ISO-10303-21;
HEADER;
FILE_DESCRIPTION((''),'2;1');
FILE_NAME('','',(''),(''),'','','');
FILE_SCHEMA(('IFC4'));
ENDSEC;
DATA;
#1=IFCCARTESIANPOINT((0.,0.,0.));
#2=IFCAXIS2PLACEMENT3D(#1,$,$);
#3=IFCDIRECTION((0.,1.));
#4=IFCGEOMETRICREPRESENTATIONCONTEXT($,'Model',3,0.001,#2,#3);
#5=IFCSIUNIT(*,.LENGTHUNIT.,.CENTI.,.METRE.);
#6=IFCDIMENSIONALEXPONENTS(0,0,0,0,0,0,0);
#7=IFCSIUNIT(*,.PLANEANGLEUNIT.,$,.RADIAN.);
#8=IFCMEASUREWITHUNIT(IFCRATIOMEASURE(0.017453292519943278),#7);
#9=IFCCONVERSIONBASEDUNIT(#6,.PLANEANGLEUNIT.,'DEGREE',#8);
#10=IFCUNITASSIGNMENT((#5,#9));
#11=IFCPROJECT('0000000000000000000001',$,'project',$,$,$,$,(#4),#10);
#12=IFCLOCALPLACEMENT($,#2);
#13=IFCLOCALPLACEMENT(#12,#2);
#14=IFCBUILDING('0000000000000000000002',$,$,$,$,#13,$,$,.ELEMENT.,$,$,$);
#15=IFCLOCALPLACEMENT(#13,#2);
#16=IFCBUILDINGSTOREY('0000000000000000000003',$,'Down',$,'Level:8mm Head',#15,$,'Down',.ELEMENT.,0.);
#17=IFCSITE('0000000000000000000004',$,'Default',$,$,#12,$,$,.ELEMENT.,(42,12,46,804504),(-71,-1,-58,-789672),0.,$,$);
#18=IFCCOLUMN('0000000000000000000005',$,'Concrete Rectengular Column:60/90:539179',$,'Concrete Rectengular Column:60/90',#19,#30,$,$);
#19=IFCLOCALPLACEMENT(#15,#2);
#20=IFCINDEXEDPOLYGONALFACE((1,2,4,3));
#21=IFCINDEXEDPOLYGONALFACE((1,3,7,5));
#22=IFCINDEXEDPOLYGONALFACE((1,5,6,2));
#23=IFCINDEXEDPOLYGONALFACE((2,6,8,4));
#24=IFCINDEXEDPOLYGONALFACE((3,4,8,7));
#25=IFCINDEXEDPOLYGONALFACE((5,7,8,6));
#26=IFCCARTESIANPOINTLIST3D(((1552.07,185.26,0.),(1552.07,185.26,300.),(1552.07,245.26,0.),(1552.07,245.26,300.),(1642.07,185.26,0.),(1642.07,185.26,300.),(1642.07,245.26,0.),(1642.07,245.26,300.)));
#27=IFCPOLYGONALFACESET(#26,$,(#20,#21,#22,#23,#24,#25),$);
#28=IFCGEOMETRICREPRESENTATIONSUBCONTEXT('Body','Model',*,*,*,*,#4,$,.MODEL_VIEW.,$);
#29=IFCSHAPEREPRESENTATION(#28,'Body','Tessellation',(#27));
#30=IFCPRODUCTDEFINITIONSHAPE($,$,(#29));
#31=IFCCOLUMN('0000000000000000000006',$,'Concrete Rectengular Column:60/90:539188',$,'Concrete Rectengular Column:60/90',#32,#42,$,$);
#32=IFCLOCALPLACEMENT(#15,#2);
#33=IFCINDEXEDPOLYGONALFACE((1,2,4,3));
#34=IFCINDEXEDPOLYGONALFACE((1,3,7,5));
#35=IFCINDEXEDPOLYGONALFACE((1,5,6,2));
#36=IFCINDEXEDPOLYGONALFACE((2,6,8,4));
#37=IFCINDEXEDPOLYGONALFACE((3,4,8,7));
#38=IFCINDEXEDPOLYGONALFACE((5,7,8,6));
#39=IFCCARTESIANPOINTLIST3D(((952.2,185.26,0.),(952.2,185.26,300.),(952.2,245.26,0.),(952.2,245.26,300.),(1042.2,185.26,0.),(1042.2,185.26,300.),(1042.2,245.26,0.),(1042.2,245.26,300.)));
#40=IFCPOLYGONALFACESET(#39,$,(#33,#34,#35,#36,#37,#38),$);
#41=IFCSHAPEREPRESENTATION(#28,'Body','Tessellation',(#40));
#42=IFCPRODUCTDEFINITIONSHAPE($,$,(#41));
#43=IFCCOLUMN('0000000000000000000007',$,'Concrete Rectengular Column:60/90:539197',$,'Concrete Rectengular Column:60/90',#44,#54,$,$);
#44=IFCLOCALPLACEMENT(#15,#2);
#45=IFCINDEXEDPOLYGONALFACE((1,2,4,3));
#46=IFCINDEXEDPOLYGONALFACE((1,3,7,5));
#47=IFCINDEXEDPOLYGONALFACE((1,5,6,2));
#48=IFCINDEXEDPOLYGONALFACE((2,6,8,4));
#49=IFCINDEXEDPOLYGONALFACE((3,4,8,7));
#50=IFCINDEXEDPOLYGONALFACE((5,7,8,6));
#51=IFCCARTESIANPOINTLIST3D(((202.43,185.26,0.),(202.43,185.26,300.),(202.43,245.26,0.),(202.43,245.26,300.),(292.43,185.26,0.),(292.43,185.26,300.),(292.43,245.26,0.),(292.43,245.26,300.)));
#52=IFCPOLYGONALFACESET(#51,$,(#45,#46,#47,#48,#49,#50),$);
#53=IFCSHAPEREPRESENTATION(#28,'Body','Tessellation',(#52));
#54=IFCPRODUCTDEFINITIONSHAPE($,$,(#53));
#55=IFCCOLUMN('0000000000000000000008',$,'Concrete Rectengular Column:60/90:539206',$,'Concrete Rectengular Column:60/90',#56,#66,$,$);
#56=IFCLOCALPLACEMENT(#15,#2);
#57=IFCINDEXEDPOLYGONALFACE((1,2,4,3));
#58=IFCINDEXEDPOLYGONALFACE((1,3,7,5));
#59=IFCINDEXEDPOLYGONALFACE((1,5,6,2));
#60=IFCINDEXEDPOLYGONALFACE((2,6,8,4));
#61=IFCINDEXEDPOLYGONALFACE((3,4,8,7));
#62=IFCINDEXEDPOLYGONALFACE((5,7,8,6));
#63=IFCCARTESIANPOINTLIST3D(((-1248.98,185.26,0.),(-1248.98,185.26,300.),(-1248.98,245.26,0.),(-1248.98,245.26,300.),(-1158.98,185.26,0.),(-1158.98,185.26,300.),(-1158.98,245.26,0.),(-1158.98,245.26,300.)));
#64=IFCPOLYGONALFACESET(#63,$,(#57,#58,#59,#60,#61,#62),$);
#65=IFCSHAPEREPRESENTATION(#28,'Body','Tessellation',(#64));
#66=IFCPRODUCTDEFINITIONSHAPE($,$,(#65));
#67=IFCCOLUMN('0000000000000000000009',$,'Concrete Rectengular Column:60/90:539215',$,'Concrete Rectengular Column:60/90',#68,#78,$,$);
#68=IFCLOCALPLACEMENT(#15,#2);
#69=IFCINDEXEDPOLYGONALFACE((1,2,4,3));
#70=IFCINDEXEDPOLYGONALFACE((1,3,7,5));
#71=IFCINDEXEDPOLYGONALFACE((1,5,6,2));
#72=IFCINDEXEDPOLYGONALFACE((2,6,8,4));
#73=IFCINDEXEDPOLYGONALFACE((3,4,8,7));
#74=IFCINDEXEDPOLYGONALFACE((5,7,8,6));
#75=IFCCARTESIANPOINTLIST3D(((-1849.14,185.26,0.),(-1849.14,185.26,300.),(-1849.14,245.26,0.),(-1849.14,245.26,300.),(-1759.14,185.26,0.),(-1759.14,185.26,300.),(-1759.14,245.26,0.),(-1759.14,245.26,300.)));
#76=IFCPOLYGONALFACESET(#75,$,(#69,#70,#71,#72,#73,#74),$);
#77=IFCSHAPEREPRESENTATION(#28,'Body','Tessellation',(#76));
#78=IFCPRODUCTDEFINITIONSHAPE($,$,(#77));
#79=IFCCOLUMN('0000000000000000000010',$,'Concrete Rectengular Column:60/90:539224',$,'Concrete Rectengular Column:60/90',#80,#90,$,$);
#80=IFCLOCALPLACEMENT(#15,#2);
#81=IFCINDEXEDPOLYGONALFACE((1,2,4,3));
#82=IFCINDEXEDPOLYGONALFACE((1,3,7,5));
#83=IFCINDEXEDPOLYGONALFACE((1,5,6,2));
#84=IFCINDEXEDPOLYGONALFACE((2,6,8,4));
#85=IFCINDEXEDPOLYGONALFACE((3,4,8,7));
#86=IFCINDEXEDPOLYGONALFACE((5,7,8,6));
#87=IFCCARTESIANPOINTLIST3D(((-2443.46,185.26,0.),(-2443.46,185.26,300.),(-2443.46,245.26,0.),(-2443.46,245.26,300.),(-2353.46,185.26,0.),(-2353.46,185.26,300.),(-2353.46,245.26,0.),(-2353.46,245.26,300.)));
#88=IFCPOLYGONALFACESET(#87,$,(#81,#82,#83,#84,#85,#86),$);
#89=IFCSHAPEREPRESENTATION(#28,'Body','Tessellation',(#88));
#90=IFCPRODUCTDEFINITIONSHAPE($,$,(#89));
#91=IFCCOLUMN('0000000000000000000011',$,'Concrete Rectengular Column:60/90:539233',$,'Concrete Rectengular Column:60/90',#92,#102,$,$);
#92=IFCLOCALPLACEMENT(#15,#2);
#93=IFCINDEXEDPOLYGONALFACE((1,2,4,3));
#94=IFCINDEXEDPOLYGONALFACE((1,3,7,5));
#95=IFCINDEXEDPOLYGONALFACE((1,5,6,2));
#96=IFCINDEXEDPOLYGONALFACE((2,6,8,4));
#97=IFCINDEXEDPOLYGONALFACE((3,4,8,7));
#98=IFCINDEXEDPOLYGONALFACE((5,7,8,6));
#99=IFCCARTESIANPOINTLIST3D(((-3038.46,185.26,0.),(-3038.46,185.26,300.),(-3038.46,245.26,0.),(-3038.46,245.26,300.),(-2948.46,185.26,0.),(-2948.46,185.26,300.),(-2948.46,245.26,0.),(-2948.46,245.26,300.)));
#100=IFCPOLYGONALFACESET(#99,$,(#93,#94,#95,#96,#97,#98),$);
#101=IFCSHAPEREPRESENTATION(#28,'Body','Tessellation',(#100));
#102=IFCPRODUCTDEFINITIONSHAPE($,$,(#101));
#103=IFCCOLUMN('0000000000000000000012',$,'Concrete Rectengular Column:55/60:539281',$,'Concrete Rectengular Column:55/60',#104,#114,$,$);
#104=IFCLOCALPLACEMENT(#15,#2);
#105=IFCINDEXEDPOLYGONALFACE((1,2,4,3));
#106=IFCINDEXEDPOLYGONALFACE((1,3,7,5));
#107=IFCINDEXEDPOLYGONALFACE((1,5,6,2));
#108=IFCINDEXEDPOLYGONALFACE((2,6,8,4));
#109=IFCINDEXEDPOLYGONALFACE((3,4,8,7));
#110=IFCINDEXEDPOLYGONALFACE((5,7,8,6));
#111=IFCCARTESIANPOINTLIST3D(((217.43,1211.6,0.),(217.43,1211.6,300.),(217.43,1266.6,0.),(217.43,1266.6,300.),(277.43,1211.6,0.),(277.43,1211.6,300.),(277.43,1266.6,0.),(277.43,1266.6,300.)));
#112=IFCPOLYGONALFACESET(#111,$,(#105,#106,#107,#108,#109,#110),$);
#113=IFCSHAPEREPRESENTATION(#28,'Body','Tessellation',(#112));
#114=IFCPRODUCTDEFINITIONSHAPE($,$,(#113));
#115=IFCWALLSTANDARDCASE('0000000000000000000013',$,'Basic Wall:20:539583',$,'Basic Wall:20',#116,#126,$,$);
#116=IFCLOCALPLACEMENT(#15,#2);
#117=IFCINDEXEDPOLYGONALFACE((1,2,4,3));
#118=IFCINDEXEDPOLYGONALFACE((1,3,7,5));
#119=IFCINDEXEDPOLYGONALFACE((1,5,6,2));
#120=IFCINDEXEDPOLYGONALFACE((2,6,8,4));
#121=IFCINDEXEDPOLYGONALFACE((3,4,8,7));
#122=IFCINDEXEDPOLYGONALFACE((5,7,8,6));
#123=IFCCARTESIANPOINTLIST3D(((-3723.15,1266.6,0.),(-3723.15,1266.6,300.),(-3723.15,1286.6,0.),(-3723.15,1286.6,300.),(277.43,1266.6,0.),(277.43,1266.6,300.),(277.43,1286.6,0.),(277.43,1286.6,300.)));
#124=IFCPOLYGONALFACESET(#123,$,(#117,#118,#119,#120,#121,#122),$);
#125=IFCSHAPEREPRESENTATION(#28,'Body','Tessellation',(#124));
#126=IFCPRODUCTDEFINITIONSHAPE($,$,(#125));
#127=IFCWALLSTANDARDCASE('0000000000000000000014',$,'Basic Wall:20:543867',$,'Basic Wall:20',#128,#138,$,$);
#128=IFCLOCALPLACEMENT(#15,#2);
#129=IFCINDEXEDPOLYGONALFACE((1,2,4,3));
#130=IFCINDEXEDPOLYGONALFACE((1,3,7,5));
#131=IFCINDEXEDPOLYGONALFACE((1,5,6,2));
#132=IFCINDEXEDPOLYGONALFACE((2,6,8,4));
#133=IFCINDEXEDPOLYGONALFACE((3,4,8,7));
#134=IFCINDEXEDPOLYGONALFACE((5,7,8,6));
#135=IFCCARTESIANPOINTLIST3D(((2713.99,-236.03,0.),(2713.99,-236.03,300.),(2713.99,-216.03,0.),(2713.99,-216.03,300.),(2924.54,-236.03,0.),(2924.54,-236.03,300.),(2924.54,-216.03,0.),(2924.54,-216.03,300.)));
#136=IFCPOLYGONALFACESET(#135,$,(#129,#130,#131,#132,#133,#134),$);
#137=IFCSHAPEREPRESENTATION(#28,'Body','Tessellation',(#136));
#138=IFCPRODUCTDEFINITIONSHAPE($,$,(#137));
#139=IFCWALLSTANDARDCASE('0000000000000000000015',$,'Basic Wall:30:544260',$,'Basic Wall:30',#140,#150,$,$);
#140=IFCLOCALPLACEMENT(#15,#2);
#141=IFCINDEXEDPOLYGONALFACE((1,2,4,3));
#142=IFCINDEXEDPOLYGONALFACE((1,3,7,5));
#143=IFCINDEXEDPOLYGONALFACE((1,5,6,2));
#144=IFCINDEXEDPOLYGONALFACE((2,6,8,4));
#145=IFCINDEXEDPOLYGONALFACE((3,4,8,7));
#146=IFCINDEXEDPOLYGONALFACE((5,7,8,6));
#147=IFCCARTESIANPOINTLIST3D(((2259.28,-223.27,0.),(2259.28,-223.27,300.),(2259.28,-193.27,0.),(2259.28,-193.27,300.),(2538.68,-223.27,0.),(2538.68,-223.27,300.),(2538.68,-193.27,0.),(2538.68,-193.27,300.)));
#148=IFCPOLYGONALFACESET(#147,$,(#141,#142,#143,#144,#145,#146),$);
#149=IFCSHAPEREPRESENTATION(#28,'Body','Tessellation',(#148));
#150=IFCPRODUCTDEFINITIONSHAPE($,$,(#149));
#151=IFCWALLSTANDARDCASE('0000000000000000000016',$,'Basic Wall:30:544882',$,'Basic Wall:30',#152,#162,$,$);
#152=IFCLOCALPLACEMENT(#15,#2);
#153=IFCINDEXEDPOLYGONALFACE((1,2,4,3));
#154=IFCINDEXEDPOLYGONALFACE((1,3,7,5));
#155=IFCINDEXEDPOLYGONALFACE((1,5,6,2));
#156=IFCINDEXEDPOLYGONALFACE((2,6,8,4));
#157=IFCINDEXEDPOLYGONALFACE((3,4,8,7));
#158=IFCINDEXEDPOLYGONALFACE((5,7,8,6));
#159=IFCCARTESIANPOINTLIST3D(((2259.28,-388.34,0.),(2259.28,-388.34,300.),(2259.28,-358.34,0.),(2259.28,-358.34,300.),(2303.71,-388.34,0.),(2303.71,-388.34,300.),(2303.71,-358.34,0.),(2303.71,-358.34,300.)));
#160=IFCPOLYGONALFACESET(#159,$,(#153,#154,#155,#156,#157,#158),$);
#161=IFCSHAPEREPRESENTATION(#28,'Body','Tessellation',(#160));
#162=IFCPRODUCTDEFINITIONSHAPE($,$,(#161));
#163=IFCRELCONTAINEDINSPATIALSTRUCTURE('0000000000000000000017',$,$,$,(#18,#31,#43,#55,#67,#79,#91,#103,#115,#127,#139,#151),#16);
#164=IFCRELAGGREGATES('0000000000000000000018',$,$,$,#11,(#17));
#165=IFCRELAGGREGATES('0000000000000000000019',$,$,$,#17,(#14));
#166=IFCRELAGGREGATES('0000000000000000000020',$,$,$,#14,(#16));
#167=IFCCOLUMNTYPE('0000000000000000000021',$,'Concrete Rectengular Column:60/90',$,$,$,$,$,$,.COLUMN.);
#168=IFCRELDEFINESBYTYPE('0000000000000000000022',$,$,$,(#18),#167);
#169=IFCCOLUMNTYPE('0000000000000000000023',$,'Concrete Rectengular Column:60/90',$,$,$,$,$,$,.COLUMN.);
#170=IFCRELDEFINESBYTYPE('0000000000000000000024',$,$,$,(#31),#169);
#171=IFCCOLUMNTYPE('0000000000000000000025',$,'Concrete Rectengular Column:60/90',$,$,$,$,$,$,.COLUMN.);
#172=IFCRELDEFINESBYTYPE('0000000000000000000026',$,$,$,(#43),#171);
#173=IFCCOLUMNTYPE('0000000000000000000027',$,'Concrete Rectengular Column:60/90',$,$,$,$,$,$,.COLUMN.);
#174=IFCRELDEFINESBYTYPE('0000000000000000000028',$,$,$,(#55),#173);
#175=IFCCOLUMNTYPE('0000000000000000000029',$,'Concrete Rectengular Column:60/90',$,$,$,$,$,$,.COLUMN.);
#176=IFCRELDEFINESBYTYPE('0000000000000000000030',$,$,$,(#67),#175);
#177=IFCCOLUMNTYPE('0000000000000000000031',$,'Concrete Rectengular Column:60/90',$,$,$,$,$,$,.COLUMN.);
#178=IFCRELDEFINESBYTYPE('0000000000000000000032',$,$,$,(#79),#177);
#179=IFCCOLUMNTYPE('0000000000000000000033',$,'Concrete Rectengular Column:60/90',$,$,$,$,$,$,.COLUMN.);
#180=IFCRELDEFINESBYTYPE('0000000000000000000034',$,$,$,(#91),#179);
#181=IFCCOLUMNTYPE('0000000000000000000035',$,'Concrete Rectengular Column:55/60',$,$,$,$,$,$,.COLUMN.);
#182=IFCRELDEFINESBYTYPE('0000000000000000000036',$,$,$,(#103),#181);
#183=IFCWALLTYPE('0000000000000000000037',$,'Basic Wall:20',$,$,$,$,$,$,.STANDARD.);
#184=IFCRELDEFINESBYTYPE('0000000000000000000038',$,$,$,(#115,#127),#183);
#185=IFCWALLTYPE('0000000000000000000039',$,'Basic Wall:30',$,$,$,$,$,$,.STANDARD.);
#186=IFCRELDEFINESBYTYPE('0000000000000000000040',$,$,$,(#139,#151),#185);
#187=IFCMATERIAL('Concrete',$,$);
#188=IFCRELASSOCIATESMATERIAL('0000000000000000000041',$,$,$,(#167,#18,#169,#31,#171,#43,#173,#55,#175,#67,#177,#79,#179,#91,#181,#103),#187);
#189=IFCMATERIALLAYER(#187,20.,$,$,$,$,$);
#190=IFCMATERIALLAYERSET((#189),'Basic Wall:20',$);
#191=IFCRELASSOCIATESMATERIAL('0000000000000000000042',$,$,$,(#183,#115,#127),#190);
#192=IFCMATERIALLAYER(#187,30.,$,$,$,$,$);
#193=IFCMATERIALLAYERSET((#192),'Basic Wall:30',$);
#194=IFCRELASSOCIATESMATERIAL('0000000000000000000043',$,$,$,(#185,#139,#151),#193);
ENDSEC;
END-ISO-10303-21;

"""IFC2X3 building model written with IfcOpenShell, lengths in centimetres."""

from ifc_helpers import new_model, entity, si_unit, converted_unit, direction, frame, frame_2d, origin, origin_2d_with_axis, place, context, subcontext, project, spatial, rectangle, extrude, source, transform, mapped, material, layer, layer_set, layer_usage, type_object, type_shapes, element, save


model = new_model("IFC2X3")

# Units and contexts
model_context = context("Model", 3, precision=0.001, world=origin(), true_north=direction((0.0, 1.0)))
body_context = subcontext(model_context, "Body", "Model", "MODEL_VIEW")
ifc_project = project(units=[si_unit("LENGTHUNIT", "METRE", prefix="CENTI"), converted_unit("PLANEANGLEUNIT", "DEGREE", entity("IfcRatioMeasure", 0.017453292519943278), si_unit("PLANEANGLEUNIT", "RADIAN"), dimensions=[0, 0, 0, 0, 0, 0, 0])], contexts=[model_context])

# Site, building, storey
site_placement = place(None, origin())
site = spatial("IfcSite", under=ifc_project, at=site_placement, Name="Default", CompositionType="ELEMENT", RefLatitude=(42, 12, 46, 804504), RefLongitude=(-71, -1, -58, -789672), RefElevation=0.0)
building_placement = place(site_placement, origin())
building = spatial("IfcBuilding", under=site, at=building_placement, CompositionType="ELEMENT")
storey_placement = place(building_placement, origin())
storey = spatial("IfcBuildingStorey", under=building, at=storey_placement, Name="Down", ObjectType="Level:8mm Head", LongName="Down", CompositionType="ELEMENT", Elevation=0.0)

# Columns
ifc_material = material(Name="Concrete")
column_type_1 = type_object("IfcColumnType", Name="Concrete Rectengular Column:60/90", PredefinedType="COLUMN", material=ifc_material)
shared_shape_1 = source(origin(), body_context, "Body", "SweptSolid", [
    extrude(rectangle(XDim=60.0, YDim=90.0, at=frame_2d((0.0, 0.0), x_axis=(1.0, 0.0))), frame((1597.07, 215.26, 0.0), z_axis=(0.0, 0.0, 1.0), x_axis=(0.0, -1.0, 0.0)), (0.0, 0.0, 1.0), 300.0),
])
type_shapes(column_type_1, [shared_shape_1])
column_1_placement = place(storey_placement, origin())
element("IfcColumn", 1, at=column_1_placement, inside=storey, type_object=column_type_1, material=ifc_material, Name="Concrete Rectengular Column:60/90:539179", ObjectType="Concrete Rectengular Column:60/90", context=body_context, shape_type="MappedRepresentation", body=[
    mapped(shared_shape_1, transform((0.0, 0.0, 0.0), scale=1.0)),
])
column_type_2 = type_object("IfcColumnType", Name="Concrete Rectengular Column:60/90", PredefinedType="COLUMN", material=ifc_material)
shared_shape_2 = source(origin(), body_context, "Body", "SweptSolid", [
    extrude(rectangle(XDim=60.0, YDim=90.0, at=frame_2d((0.0, 0.0), x_axis=(1.0, 0.0))), frame((997.2, 215.26, 0.0), z_axis=(0.0, 0.0, 1.0), x_axis=(0.0, -1.0, 0.0)), (0.0, 0.0, 1.0), 300.0),
])
type_shapes(column_type_2, [shared_shape_2])
column_2_placement = place(storey_placement, origin())
element("IfcColumn", 2, at=column_2_placement, inside=storey, type_object=column_type_2, material=ifc_material, Name="Concrete Rectengular Column:60/90:539188", ObjectType="Concrete Rectengular Column:60/90", context=body_context, shape_type="MappedRepresentation", body=[
    mapped(shared_shape_2, transform((0.0, 0.0, 0.0), scale=1.0)),
])
column_type_3 = type_object("IfcColumnType", Name="Concrete Rectengular Column:60/90", PredefinedType="COLUMN", material=ifc_material)
shared_shape_3 = source(origin(), body_context, "Body", "SweptSolid", [
    extrude(rectangle(XDim=60.0, YDim=90.0, at=frame_2d((0.0, 0.0), x_axis=(1.0, 0.0))), frame((247.43, 215.26, 0.0), z_axis=(0.0, 0.0, 1.0), x_axis=(0.0, -1.0, 0.0)), (0.0, 0.0, 1.0), 300.0),
])
type_shapes(column_type_3, [shared_shape_3])
column_3_placement = place(storey_placement, origin())
element("IfcColumn", 3, at=column_3_placement, inside=storey, type_object=column_type_3, material=ifc_material, Name="Concrete Rectengular Column:60/90:539197", ObjectType="Concrete Rectengular Column:60/90", context=body_context, shape_type="MappedRepresentation", body=[
    mapped(shared_shape_3, transform((0.0, 0.0, 0.0), scale=1.0)),
])
column_type_4 = type_object("IfcColumnType", Name="Concrete Rectengular Column:60/90", PredefinedType="COLUMN", material=ifc_material)
shared_shape_4 = source(origin(), body_context, "Body", "SweptSolid", [
    extrude(rectangle(XDim=60.0, YDim=90.0, at=frame_2d((0.0, 0.0), x_axis=(1.0, 0.0))), frame((-1203.98, 215.26, 0.0), z_axis=(0.0, 0.0, 1.0), x_axis=(0.0, -1.0, 0.0)), (0.0, 0.0, 1.0), 300.0),
])
type_shapes(column_type_4, [shared_shape_4])
column_4_placement = place(storey_placement, origin())
element("IfcColumn", 4, at=column_4_placement, inside=storey, type_object=column_type_4, material=ifc_material, Name="Concrete Rectengular Column:60/90:539206", ObjectType="Concrete Rectengular Column:60/90", context=body_context, shape_type="MappedRepresentation", body=[
    mapped(shared_shape_4, transform((0.0, 0.0, 0.0), scale=1.0)),
])
column_type_5 = type_object("IfcColumnType", Name="Concrete Rectengular Column:60/90", PredefinedType="COLUMN", material=ifc_material)
shared_shape_5 = source(origin(), body_context, "Body", "SweptSolid", [
    extrude(rectangle(XDim=60.0, YDim=90.0, at=frame_2d((0.0, 0.0), x_axis=(1.0, 0.0))), frame((-1804.14, 215.26, 0.0), z_axis=(0.0, 0.0, 1.0), x_axis=(0.0, -1.0, 0.0)), (0.0, 0.0, 1.0), 300.0),
])
type_shapes(column_type_5, [shared_shape_5])
column_5_placement = place(storey_placement, origin())
element("IfcColumn", 5, at=column_5_placement, inside=storey, type_object=column_type_5, material=ifc_material, Name="Concrete Rectengular Column:60/90:539215", ObjectType="Concrete Rectengular Column:60/90", context=body_context, shape_type="MappedRepresentation", body=[
    mapped(shared_shape_5, transform((0.0, 0.0, 0.0), scale=1.0)),
])
column_type_6 = type_object("IfcColumnType", Name="Concrete Rectengular Column:60/90", PredefinedType="COLUMN", material=ifc_material)
shared_shape_6 = source(origin(), body_context, "Body", "SweptSolid", [
    extrude(rectangle(XDim=60.0, YDim=90.0, at=frame_2d((0.0, 0.0), x_axis=(1.0, 0.0))), frame((-2398.46, 215.26, 0.0), z_axis=(0.0, 0.0, 1.0), x_axis=(0.0, -1.0, 0.0)), (0.0, 0.0, 1.0), 300.0),
])
type_shapes(column_type_6, [shared_shape_6])
column_6_placement = place(storey_placement, origin())
element("IfcColumn", 6, at=column_6_placement, inside=storey, type_object=column_type_6, material=ifc_material, Name="Concrete Rectengular Column:60/90:539224", ObjectType="Concrete Rectengular Column:60/90", context=body_context, shape_type="MappedRepresentation", body=[
    mapped(shared_shape_6, transform((0.0, 0.0, 0.0), scale=1.0)),
])
column_type_7 = type_object("IfcColumnType", Name="Concrete Rectengular Column:60/90", PredefinedType="COLUMN", material=ifc_material)
shared_shape_7 = source(origin(), body_context, "Body", "SweptSolid", [
    extrude(rectangle(XDim=60.0, YDim=90.0, at=frame_2d((0.0, 0.0), x_axis=(1.0, 0.0))), frame((-2993.46, 215.26, 0.0), z_axis=(0.0, 0.0, 1.0), x_axis=(0.0, -1.0, 0.0)), (0.0, 0.0, 1.0), 300.0),
])
type_shapes(column_type_7, [shared_shape_7])
column_7_placement = place(storey_placement, origin())
element("IfcColumn", 7, at=column_7_placement, inside=storey, type_object=column_type_7, material=ifc_material, Name="Concrete Rectengular Column:60/90:539233", ObjectType="Concrete Rectengular Column:60/90", context=body_context, shape_type="MappedRepresentation", body=[
    mapped(shared_shape_7, transform((0.0, 0.0, 0.0), scale=1.0)),
])
column_type_8 = type_object("IfcColumnType", Name="Concrete Rectengular Column:55/60", PredefinedType="COLUMN", material=ifc_material)
shared_shape_8 = source(origin(), body_context, "Body", "SweptSolid", [
    extrude(rectangle(XDim=55.0, YDim=60.0, at=origin_2d_with_axis()), frame((247.43, 1239.1, 0.0), z_axis=(0.0, 0.0, 1.0), x_axis=(0.0, -1.0, 0.0)), (0.0, 0.0, 1.0), 300.0),
])
type_shapes(column_type_8, [shared_shape_8])
column_8_placement = place(storey_placement, origin())
element("IfcColumn", 8, at=column_8_placement, inside=storey, type_object=column_type_8, material=ifc_material, Name="Concrete Rectengular Column:55/60:539281", ObjectType="Concrete Rectengular Column:55/60", context=body_context, shape_type="MappedRepresentation", body=[
    mapped(shared_shape_8, transform((0.0, 0.0, 0.0), scale=1.0)),
])

# Walls
ifc_layer_1 = layer(ifc_material, 20.0)
ifc_layer_set_1 = layer_set([ifc_layer_1], Name="Basic Wall:20")
ifc_layer_usage_1 = layer_usage(ifc_layer_set_1, "AXIS2", "NEGATIVE", 10.0)
wall_type_1 = type_object("IfcWallType", Name="Basic Wall:20", PredefinedType="STANDARD", material=ifc_layer_set_1)
wall_1_placement = place(storey_placement, frame((277.43, 1276.6, 0.0), z_axis=(0.0, 0.0, 1.0), x_axis=(-1.0, 0.0, 0.0)))
element("IfcWallStandardCase", 9, at=wall_1_placement, inside=storey, type_object=wall_type_1, material=ifc_layer_usage_1, Name="Basic Wall:20:539583", ObjectType="Basic Wall:20", context=body_context, shape_type="SweptSolid", body=[
    extrude(rectangle(XDim=4000.59, YDim=20.0, at=frame_2d((2000.29, 0.0), x_axis=(-1.0, 0.0))), origin(), (0.0, 0.0, 1.0), 300.0),
])
ifc_layer_usage_2 = layer_usage(ifc_layer_set_1, "AXIS2", "NEGATIVE", 10.0)
wall_2_placement = place(storey_placement, frame((2924.54, -226.03, 0.0), z_axis=(0.0, 0.0, 1.0), x_axis=(-1.0, 0.0, 0.0)))
element("IfcWallStandardCase", 10, at=wall_2_placement, inside=storey, type_object=wall_type_1, material=ifc_layer_usage_2, Name="Basic Wall:20:543867", ObjectType="Basic Wall:20", context=body_context, shape_type="SweptSolid", body=[
    extrude(rectangle(XDim=210.54, YDim=20.0, at=frame_2d((105.27, 0.0), x_axis=(-1.0, 0.0))), origin(), (0.0, 0.0, 1.0), 300.0),
])
ifc_layer_2 = layer(ifc_material, 30.0)
ifc_layer_set_2 = layer_set([ifc_layer_2], Name="Basic Wall:30")
ifc_layer_usage_3 = layer_usage(ifc_layer_set_2, "AXIS2", "POSITIVE", -15.0)
wall_type_2 = type_object("IfcWallType", Name="Basic Wall:30", PredefinedType="STANDARD", material=ifc_layer_set_2)
wall_3_placement = place(storey_placement, frame((2538.68, -208.27, 0.0), z_axis=(0.0, 0.0, 1.0), x_axis=(-1.0, 0.0, 0.0)))
element("IfcWallStandardCase", 11, at=wall_3_placement, inside=storey, type_object=wall_type_2, material=ifc_layer_usage_3, Name="Basic Wall:30:544260", ObjectType="Basic Wall:30", context=body_context, shape_type="SweptSolid", body=[
    extrude(rectangle(XDim=279.4, YDim=30.0, at=frame_2d((139.7, 0.0), x_axis=(-1.0, 0.0))), origin(), (0.0, 0.0, 1.0), 300.0),
])
ifc_layer_usage_4 = layer_usage(ifc_layer_set_2, "AXIS2", "NEGATIVE", 15.0)
wall_4_placement = place(storey_placement, frame((2259.28, -373.34, 0.0)))
element("IfcWallStandardCase", 12, at=wall_4_placement, inside=storey, type_object=wall_type_2, material=ifc_layer_usage_4, Name="Basic Wall:30:544882", ObjectType="Basic Wall:30", context=body_context, shape_type="SweptSolid", body=[
    extrude(rectangle(XDim=44.43, YDim=30.0, at=frame_2d((22.21, 0.0), x_axis=(-1.0, 0.0))), origin(), (0.0, 0.0, 1.0), 300.0),
])

save(model, "model.ifc")
